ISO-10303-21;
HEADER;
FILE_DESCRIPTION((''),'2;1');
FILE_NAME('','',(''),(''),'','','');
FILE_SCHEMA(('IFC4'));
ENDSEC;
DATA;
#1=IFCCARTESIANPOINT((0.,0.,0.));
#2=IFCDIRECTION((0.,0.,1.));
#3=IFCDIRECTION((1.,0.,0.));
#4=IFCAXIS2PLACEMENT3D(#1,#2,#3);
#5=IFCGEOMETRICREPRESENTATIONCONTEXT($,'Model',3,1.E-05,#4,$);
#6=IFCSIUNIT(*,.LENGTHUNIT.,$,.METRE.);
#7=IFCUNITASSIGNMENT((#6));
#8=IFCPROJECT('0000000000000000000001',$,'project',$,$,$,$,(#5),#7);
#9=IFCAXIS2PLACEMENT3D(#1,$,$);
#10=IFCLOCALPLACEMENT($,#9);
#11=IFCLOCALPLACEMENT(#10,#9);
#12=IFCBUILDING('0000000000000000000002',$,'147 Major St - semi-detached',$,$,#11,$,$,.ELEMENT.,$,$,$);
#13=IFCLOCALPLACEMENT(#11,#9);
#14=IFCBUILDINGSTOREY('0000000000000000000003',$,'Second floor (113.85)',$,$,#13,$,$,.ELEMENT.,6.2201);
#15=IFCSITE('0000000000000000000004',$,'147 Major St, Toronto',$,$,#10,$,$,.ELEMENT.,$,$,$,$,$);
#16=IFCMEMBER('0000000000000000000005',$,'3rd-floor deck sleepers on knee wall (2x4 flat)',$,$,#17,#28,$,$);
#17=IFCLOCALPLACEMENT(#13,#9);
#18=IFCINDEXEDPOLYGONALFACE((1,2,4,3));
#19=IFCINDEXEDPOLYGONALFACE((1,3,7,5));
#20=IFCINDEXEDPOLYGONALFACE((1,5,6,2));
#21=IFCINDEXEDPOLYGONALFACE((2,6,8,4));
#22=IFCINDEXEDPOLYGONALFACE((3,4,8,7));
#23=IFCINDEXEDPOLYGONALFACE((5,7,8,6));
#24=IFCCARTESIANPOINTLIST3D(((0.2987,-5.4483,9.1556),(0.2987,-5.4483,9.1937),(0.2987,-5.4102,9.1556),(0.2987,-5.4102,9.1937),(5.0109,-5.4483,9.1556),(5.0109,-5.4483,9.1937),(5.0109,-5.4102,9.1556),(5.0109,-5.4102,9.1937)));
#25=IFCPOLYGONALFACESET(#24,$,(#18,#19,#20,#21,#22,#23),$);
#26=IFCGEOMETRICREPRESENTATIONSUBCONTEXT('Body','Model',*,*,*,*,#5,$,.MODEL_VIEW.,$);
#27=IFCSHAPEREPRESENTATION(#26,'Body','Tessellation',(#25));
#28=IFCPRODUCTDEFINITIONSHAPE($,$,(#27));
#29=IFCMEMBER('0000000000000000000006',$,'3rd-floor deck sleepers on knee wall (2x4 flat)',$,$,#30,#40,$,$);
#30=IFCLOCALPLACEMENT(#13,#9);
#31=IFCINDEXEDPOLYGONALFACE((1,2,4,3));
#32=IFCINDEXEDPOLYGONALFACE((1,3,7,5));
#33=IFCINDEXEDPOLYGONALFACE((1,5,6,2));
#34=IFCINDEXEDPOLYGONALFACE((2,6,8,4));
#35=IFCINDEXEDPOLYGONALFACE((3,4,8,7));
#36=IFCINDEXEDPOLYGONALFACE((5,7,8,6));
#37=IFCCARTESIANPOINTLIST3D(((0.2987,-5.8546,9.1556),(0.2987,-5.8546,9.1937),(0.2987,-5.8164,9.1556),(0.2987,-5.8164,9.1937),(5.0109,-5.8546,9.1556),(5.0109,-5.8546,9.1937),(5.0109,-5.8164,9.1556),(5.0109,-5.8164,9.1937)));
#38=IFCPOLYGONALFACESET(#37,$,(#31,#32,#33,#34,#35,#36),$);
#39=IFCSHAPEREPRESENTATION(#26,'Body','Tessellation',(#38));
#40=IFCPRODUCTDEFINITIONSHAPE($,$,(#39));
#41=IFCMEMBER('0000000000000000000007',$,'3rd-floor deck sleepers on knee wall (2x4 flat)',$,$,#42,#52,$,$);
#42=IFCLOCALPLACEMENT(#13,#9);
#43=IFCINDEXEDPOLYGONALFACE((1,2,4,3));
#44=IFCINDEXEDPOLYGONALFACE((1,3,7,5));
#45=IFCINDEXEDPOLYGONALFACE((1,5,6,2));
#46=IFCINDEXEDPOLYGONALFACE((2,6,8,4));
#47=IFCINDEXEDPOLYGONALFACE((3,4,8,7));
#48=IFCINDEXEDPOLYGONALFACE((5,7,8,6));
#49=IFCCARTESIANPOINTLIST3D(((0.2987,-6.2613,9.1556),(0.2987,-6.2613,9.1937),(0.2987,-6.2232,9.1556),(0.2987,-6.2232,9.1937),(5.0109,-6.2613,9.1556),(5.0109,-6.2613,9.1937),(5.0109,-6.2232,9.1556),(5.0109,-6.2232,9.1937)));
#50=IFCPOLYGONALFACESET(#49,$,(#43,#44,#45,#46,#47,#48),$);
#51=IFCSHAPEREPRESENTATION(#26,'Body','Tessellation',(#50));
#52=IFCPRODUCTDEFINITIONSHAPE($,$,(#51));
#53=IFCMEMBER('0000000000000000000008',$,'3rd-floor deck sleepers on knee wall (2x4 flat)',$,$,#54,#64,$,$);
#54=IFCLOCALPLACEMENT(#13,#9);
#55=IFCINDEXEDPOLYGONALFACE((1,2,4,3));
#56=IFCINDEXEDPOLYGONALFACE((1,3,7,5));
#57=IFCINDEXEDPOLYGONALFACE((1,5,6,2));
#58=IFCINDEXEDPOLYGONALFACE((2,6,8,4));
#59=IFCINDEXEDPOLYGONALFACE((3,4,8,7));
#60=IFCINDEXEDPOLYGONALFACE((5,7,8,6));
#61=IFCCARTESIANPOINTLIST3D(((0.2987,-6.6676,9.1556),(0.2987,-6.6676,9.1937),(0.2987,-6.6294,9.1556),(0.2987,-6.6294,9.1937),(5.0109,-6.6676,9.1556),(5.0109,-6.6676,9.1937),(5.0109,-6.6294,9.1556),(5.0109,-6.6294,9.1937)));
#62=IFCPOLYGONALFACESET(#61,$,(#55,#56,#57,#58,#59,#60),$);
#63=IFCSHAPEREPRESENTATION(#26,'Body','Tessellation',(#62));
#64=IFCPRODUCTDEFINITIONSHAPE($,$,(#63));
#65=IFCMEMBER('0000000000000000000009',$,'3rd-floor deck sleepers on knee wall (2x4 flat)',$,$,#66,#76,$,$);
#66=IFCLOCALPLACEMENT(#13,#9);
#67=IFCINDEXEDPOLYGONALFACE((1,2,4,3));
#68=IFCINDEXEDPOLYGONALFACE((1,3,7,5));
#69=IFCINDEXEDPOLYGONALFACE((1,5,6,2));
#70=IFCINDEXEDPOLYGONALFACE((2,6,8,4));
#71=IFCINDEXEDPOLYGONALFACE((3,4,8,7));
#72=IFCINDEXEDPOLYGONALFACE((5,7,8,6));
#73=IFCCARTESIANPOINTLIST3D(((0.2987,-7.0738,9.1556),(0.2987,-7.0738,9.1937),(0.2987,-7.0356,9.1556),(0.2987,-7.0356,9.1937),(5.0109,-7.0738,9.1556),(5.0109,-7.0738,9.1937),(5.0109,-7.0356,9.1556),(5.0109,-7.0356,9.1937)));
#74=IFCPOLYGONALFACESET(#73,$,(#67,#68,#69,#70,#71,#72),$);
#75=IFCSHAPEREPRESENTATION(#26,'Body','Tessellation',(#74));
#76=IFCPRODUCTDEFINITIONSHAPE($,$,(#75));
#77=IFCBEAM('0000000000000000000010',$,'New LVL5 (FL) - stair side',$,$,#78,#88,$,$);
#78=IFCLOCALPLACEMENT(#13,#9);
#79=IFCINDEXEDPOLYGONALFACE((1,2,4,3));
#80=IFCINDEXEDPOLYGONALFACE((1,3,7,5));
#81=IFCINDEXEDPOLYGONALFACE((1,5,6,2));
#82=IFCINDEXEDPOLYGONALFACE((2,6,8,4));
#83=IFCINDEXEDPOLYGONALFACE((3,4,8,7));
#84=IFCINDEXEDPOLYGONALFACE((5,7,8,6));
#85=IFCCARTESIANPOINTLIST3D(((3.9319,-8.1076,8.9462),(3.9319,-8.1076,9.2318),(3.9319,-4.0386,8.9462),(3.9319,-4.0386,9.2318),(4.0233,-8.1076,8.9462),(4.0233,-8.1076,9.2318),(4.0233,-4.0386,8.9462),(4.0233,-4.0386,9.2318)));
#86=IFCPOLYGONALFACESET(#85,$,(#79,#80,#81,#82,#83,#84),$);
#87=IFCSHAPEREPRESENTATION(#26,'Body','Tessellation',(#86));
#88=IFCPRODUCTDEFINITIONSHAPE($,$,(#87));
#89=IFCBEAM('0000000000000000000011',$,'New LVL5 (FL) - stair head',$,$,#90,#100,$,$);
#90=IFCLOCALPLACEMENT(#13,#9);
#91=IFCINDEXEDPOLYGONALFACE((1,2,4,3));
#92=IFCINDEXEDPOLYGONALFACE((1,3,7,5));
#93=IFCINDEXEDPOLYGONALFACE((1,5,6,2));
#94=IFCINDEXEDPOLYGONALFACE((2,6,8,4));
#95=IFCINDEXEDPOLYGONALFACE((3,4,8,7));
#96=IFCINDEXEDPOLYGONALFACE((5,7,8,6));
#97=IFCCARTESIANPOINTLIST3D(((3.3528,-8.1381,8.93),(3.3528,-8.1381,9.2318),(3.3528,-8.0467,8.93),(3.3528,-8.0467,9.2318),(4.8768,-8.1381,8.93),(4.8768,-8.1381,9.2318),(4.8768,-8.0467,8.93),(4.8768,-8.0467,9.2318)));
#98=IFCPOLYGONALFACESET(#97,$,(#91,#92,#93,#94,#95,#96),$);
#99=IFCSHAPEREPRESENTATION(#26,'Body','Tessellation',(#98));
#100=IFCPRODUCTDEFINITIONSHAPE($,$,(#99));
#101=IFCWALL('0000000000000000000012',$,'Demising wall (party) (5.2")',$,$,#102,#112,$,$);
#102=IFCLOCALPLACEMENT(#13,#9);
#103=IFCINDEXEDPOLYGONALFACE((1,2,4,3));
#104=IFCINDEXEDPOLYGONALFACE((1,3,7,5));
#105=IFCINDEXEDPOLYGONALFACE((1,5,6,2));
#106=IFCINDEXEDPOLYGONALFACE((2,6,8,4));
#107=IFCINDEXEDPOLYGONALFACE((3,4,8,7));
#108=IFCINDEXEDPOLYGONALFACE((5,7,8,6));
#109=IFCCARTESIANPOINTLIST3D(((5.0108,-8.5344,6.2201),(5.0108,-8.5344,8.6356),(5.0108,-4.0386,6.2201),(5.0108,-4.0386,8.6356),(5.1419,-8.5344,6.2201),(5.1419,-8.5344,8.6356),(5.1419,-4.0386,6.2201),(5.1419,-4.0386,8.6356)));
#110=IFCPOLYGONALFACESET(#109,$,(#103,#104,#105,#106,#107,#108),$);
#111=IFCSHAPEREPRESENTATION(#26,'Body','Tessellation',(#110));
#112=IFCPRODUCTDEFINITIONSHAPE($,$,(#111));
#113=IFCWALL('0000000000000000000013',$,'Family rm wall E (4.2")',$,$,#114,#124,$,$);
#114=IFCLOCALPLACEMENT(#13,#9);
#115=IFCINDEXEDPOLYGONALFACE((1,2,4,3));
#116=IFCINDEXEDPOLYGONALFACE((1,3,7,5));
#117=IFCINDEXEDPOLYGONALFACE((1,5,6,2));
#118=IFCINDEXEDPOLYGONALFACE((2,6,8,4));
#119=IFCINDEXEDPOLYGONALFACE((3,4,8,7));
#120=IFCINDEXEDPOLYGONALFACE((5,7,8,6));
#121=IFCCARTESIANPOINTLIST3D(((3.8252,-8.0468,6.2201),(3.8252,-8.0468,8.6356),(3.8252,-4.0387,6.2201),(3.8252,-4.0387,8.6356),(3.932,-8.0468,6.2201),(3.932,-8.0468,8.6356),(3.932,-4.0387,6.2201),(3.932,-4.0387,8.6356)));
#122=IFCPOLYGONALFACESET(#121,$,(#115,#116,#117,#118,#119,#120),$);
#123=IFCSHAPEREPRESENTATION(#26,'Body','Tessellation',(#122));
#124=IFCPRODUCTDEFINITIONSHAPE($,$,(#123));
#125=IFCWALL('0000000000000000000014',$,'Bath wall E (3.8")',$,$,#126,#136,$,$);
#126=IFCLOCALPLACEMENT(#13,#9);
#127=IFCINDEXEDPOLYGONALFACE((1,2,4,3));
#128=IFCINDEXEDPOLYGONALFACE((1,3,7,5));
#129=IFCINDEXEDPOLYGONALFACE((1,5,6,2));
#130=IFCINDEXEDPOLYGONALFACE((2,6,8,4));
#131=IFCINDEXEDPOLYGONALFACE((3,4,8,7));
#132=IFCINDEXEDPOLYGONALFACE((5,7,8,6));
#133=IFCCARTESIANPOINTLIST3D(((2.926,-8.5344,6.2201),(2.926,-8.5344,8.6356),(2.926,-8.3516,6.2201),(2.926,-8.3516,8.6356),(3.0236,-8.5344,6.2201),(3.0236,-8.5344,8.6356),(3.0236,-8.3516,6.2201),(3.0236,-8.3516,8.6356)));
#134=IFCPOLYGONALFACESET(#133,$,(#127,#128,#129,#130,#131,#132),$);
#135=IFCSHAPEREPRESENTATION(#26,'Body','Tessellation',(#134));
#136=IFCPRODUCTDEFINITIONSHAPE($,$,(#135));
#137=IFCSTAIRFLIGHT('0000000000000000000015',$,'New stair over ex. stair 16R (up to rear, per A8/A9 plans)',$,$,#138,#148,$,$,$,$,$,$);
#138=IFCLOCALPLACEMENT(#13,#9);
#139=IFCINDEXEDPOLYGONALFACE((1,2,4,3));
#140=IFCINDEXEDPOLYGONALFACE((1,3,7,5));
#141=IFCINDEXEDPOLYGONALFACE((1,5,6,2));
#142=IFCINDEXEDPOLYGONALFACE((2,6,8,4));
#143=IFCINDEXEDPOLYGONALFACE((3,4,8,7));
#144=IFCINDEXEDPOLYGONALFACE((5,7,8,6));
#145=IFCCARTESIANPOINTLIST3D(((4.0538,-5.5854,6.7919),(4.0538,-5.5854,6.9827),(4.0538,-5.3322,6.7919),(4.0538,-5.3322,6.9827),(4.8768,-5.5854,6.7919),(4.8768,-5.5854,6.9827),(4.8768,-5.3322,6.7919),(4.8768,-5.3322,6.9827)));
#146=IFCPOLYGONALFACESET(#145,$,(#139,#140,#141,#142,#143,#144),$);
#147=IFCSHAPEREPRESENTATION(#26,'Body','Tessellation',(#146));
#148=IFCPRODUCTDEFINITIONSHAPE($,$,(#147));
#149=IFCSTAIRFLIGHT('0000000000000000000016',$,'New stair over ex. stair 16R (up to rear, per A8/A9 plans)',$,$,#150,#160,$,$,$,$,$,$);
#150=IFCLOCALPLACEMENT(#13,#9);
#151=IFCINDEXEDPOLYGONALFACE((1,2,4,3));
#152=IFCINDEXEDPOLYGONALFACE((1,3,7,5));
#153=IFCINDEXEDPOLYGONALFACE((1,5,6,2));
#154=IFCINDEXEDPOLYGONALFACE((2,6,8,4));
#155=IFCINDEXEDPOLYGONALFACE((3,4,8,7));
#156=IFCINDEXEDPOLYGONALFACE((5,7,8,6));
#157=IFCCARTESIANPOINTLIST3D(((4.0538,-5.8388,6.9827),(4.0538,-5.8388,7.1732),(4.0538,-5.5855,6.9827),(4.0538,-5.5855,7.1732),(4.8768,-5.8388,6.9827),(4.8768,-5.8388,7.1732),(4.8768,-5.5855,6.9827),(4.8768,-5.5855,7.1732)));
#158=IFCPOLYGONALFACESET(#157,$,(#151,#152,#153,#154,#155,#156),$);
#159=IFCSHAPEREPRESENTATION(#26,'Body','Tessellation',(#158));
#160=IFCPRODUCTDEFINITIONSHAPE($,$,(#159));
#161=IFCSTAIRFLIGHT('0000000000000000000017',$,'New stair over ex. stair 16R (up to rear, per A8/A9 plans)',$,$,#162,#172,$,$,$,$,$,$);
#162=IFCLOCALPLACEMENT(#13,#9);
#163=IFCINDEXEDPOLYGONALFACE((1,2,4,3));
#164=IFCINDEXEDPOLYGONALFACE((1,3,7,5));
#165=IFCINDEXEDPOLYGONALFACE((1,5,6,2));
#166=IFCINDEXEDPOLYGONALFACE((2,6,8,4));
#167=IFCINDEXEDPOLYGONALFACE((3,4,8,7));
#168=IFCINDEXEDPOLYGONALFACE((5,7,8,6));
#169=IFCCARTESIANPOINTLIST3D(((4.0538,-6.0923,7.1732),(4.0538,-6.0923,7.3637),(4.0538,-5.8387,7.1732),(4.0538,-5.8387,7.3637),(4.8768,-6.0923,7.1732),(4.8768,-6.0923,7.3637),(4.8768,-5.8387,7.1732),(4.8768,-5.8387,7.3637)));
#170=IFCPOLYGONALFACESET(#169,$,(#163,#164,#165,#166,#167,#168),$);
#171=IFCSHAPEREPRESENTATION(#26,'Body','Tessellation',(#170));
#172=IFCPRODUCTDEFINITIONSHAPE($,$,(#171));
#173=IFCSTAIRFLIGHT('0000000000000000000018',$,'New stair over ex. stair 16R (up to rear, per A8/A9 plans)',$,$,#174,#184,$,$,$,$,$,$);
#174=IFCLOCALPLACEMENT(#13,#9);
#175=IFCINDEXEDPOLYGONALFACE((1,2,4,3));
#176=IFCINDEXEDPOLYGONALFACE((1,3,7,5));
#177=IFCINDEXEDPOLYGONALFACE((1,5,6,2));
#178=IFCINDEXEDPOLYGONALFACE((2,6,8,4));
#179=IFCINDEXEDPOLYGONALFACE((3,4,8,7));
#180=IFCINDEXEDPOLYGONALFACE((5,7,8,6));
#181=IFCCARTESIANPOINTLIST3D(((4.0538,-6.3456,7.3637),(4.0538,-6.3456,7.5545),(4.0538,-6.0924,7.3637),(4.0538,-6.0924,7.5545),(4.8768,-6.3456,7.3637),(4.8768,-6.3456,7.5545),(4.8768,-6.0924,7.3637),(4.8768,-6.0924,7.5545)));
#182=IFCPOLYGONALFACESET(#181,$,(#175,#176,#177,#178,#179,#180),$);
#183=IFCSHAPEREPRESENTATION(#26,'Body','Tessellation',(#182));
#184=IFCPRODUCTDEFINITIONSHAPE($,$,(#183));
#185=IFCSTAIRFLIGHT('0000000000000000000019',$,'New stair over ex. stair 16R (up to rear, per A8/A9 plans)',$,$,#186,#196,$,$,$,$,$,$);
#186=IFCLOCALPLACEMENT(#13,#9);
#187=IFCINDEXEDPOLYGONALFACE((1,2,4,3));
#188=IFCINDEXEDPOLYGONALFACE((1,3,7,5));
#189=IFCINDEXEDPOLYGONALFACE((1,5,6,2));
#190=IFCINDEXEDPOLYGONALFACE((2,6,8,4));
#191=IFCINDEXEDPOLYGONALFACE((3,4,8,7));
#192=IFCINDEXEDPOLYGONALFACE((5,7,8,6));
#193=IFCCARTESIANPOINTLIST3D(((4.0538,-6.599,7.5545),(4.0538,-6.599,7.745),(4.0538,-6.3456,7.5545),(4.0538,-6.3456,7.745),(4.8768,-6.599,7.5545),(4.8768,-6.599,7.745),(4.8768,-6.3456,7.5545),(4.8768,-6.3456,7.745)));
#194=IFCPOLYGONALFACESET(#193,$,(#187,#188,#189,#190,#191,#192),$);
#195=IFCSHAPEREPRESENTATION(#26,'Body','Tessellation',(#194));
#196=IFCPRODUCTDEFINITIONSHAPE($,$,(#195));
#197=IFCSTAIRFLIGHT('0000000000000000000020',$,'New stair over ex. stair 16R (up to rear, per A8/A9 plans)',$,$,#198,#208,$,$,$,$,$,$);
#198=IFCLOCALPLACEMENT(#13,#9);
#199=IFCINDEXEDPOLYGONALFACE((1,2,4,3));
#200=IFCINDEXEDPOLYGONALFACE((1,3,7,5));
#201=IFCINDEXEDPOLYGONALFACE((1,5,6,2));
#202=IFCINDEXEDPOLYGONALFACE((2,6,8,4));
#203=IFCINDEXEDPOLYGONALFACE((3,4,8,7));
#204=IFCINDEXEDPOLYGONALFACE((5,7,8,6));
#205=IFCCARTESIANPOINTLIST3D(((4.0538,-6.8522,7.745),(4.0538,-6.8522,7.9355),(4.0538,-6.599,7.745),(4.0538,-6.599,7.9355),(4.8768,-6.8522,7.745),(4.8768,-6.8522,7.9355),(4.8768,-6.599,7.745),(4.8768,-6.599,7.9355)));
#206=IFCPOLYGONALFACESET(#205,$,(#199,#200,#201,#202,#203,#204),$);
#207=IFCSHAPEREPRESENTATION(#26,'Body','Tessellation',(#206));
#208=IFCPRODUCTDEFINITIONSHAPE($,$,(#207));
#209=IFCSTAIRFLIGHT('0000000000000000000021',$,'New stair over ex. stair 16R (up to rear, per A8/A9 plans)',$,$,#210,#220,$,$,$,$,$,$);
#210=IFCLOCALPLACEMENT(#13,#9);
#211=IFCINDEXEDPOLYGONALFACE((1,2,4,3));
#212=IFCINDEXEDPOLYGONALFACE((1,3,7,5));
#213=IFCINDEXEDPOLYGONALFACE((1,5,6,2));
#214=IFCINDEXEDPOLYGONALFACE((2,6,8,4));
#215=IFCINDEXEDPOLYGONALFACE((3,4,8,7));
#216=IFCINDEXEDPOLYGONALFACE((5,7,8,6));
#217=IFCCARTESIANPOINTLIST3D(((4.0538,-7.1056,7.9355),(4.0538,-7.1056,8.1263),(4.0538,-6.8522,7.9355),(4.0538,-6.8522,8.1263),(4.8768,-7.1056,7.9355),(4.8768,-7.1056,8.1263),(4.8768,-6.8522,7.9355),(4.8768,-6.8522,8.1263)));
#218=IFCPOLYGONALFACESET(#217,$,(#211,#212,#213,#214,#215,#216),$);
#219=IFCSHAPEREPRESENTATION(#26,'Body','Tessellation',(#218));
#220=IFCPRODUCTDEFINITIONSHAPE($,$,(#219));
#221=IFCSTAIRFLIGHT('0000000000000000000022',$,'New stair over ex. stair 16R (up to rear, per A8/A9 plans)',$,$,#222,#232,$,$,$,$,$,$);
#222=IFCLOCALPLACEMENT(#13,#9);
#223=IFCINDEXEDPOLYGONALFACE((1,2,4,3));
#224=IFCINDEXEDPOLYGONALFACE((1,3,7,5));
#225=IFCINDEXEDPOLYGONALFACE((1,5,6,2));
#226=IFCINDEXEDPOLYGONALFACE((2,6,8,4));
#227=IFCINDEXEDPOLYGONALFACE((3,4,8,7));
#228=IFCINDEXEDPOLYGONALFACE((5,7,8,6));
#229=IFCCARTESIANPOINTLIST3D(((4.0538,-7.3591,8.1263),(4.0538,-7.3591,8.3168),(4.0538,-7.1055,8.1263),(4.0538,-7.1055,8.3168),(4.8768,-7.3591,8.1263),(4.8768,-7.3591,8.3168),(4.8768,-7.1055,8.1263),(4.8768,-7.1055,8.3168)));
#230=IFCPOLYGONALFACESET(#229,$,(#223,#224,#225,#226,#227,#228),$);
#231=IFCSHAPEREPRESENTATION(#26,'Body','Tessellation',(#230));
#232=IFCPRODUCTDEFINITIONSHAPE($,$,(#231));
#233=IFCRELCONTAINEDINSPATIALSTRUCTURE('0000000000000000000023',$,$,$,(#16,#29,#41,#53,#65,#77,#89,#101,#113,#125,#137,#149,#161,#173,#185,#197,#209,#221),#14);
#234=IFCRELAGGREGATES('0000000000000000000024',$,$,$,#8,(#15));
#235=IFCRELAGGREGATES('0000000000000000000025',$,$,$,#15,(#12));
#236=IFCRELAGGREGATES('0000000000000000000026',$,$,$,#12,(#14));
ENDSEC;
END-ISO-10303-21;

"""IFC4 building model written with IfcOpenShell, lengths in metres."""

from ifc_helpers import new_model, si_unit, frame, origin, origin_with_axes, place, context, subcontext, project, spatial, rectangle, extrude, element, save


model = new_model("IFC4")

# Units and contexts
model_context = context("Model", 3, precision=1e-05, world=origin_with_axes())
body_context = subcontext(model_context, "Body", "Model", "MODEL_VIEW")
ifc_project = project(units=[si_unit("LENGTHUNIT", "METRE")], contexts=[model_context])

# Site, building, storey
site_placement = place(None, origin())
site = spatial("IfcSite", under=ifc_project, at=site_placement, Name="147 Major St, Toronto", CompositionType="ELEMENT")
building_placement = place(site_placement, origin())
building = spatial("IfcBuilding", under=site, at=building_placement, Name="147 Major St - semi-detached", CompositionType="ELEMENT")
storey_placement = place(building_placement, origin())
storey = spatial("IfcBuildingStorey", under=building, at=storey_placement, Name="Second floor (113.85)", CompositionType="ELEMENT", Elevation=6.2201)

# Members
for number, where, name in (
    (1, (2.6548, -5.4293, 9.1556), "3rd-floor deck sleepers on knee wall (2x4 flat)"),
    (2, (2.6548, -5.8355, 9.1556), "3rd-floor deck sleepers on knee wall (2x4 flat)"),
    (3, (2.6548, -6.2422, 9.1556), "3rd-floor deck sleepers on knee wall (2x4 flat)"),
    (4, (2.6548, -6.6485, 9.1556), "3rd-floor deck sleepers on knee wall (2x4 flat)"),
    (5, (2.6548, -7.0547, 9.1556), "3rd-floor deck sleepers on knee wall (2x4 flat)"),
):
    element("IfcMember", number, at=place(storey_placement, frame(where)), inside=storey, Name=name, context=body_context, shape_type="SweptSolid", body=[
        extrude(rectangle(XDim=4.7122, YDim=0.0381), origin_with_axes(), (0.0, 0.0, 1.0), 0.0381),
    ])

# Beams
beam_1_placement = place(storey_placement, frame((3.9776, -6.0731, 8.9462)))
element("IfcBeam", 6, at=beam_1_placement, inside=storey, Name="New LVL5 (FL) - stair side", context=body_context, shape_type="SweptSolid", body=[
    extrude(rectangle(XDim=0.0914, YDim=4.0691), origin_with_axes(), (0.0, 0.0, 1.0), 0.2856),
])
beam_2_placement = place(storey_placement, frame((4.1148, -8.0924, 8.93)))
element("IfcBeam", 7, at=beam_2_placement, inside=storey, Name="New LVL5 (FL) - stair head", context=body_context, shape_type="SweptSolid", body=[
    extrude(rectangle(XDim=1.524, YDim=0.0914), origin_with_axes(), (0.0, 0.0, 1.0), 0.3018),
])

# Walls
wall_1_placement = place(storey_placement, frame((5.0764, -6.2865, 6.2201)))
element("IfcWall", 8, at=wall_1_placement, inside=storey, Name="Demising wall (party) (5.2\")", context=body_context, shape_type="SweptSolid", body=[
    extrude(rectangle(XDim=0.1311, YDim=4.4958), origin_with_axes(), (0.0, 0.0, 1.0), 2.4155),
])
wall_2_placement = place(storey_placement, frame((3.8786, -6.0427, 6.2201)))
element("IfcWall", 9, at=wall_2_placement, inside=storey, Name="Family rm wall E (4.2\")", context=body_context, shape_type="SweptSolid", body=[
    extrude(rectangle(XDim=0.1067, YDim=4.0081), origin_with_axes(), (0.0, 0.0, 1.0), 2.4155),
])
wall_3_placement = place(storey_placement, frame((2.9748, -8.443, 6.2201)))
element("IfcWall", 10, at=wall_3_placement, inside=storey, Name="Bath wall E (3.8\")", context=body_context, shape_type="SweptSolid", body=[
    extrude(rectangle(XDim=0.0975, YDim=0.1829), origin_with_axes(), (0.0, 0.0, 1.0), 2.4155),
])

# Stair flights
stair_flight_1_placement = place(storey_placement, frame((4.4653, -5.4588, 6.7919)))
element("IfcStairFlight", 11, at=stair_flight_1_placement, inside=storey, Name="New stair over ex. stair 16R (up to rear, per A8/A9 plans)", context=body_context, shape_type="SweptSolid", body=[
    extrude(rectangle(XDim=0.823, YDim=0.2533), origin_with_axes(), (0.0, 0.0, 1.0), 0.1908),
])
stair_flight_2_placement = place(storey_placement, frame((4.4653, -5.7121, 6.9827)))
element("IfcStairFlight", 12, at=stair_flight_2_placement, inside=storey, Name="New stair over ex. stair 16R (up to rear, per A8/A9 plans)", context=body_context, shape_type="SweptSolid", body=[
    extrude(rectangle(XDim=0.823, YDim=0.2533), origin_with_axes(), (0.0, 0.0, 1.0), 0.1905),
])
stair_flight_3_placement = place(storey_placement, frame((4.4653, -5.9655, 7.1732)))
element("IfcStairFlight", 13, at=stair_flight_3_placement, inside=storey, Name="New stair over ex. stair 16R (up to rear, per A8/A9 plans)", context=body_context, shape_type="SweptSolid", body=[
    extrude(rectangle(XDim=0.823, YDim=0.2536), origin_with_axes(), (0.0, 0.0, 1.0), 0.1905),
])
stair_flight_4_placement = place(storey_placement, frame((4.4653, -6.219, 7.3637)))
element("IfcStairFlight", 14, at=stair_flight_4_placement, inside=storey, Name="New stair over ex. stair 16R (up to rear, per A8/A9 plans)", context=body_context, shape_type="SweptSolid", body=[
    extrude(rectangle(XDim=0.823, YDim=0.2533), origin_with_axes(), (0.0, 0.0, 1.0), 0.1908),
])
for number, where, name in (
    (15, (4.4653, -6.4723, 7.5545), "New stair over ex. stair 16R (up to rear, per A8/A9 plans)"),
    (16, (4.4653, -6.7256, 7.745), "New stair over ex. stair 16R (up to rear, per A8/A9 plans)"),
):
    element("IfcStairFlight", number, at=place(storey_placement, frame(where)), inside=storey, Name=name, context=body_context, shape_type="SweptSolid", body=[
        extrude(rectangle(XDim=0.823, YDim=0.2533), origin_with_axes(), (0.0, 0.0, 1.0), 0.1905),
    ])
stair_flight_5_placement = place(storey_placement, frame((4.4653, -6.9789, 7.9355)))
element("IfcStairFlight", 17, at=stair_flight_5_placement, inside=storey, Name="New stair over ex. stair 16R (up to rear, per A8/A9 plans)", context=body_context, shape_type="SweptSolid", body=[
    extrude(rectangle(XDim=0.823, YDim=0.2533), origin_with_axes(), (0.0, 0.0, 1.0), 0.1908),
])
stair_flight_6_placement = place(storey_placement, frame((4.4653, -7.2323, 8.1263)))
element("IfcStairFlight", 18, at=stair_flight_6_placement, inside=storey, Name="New stair over ex. stair 16R (up to rear, per A8/A9 plans)", context=body_context, shape_type="SweptSolid", body=[
    extrude(rectangle(XDim=0.823, YDim=0.2536), origin_with_axes(), (0.0, 0.0, 1.0), 0.1905),
])

save(model, "model.ifc")
